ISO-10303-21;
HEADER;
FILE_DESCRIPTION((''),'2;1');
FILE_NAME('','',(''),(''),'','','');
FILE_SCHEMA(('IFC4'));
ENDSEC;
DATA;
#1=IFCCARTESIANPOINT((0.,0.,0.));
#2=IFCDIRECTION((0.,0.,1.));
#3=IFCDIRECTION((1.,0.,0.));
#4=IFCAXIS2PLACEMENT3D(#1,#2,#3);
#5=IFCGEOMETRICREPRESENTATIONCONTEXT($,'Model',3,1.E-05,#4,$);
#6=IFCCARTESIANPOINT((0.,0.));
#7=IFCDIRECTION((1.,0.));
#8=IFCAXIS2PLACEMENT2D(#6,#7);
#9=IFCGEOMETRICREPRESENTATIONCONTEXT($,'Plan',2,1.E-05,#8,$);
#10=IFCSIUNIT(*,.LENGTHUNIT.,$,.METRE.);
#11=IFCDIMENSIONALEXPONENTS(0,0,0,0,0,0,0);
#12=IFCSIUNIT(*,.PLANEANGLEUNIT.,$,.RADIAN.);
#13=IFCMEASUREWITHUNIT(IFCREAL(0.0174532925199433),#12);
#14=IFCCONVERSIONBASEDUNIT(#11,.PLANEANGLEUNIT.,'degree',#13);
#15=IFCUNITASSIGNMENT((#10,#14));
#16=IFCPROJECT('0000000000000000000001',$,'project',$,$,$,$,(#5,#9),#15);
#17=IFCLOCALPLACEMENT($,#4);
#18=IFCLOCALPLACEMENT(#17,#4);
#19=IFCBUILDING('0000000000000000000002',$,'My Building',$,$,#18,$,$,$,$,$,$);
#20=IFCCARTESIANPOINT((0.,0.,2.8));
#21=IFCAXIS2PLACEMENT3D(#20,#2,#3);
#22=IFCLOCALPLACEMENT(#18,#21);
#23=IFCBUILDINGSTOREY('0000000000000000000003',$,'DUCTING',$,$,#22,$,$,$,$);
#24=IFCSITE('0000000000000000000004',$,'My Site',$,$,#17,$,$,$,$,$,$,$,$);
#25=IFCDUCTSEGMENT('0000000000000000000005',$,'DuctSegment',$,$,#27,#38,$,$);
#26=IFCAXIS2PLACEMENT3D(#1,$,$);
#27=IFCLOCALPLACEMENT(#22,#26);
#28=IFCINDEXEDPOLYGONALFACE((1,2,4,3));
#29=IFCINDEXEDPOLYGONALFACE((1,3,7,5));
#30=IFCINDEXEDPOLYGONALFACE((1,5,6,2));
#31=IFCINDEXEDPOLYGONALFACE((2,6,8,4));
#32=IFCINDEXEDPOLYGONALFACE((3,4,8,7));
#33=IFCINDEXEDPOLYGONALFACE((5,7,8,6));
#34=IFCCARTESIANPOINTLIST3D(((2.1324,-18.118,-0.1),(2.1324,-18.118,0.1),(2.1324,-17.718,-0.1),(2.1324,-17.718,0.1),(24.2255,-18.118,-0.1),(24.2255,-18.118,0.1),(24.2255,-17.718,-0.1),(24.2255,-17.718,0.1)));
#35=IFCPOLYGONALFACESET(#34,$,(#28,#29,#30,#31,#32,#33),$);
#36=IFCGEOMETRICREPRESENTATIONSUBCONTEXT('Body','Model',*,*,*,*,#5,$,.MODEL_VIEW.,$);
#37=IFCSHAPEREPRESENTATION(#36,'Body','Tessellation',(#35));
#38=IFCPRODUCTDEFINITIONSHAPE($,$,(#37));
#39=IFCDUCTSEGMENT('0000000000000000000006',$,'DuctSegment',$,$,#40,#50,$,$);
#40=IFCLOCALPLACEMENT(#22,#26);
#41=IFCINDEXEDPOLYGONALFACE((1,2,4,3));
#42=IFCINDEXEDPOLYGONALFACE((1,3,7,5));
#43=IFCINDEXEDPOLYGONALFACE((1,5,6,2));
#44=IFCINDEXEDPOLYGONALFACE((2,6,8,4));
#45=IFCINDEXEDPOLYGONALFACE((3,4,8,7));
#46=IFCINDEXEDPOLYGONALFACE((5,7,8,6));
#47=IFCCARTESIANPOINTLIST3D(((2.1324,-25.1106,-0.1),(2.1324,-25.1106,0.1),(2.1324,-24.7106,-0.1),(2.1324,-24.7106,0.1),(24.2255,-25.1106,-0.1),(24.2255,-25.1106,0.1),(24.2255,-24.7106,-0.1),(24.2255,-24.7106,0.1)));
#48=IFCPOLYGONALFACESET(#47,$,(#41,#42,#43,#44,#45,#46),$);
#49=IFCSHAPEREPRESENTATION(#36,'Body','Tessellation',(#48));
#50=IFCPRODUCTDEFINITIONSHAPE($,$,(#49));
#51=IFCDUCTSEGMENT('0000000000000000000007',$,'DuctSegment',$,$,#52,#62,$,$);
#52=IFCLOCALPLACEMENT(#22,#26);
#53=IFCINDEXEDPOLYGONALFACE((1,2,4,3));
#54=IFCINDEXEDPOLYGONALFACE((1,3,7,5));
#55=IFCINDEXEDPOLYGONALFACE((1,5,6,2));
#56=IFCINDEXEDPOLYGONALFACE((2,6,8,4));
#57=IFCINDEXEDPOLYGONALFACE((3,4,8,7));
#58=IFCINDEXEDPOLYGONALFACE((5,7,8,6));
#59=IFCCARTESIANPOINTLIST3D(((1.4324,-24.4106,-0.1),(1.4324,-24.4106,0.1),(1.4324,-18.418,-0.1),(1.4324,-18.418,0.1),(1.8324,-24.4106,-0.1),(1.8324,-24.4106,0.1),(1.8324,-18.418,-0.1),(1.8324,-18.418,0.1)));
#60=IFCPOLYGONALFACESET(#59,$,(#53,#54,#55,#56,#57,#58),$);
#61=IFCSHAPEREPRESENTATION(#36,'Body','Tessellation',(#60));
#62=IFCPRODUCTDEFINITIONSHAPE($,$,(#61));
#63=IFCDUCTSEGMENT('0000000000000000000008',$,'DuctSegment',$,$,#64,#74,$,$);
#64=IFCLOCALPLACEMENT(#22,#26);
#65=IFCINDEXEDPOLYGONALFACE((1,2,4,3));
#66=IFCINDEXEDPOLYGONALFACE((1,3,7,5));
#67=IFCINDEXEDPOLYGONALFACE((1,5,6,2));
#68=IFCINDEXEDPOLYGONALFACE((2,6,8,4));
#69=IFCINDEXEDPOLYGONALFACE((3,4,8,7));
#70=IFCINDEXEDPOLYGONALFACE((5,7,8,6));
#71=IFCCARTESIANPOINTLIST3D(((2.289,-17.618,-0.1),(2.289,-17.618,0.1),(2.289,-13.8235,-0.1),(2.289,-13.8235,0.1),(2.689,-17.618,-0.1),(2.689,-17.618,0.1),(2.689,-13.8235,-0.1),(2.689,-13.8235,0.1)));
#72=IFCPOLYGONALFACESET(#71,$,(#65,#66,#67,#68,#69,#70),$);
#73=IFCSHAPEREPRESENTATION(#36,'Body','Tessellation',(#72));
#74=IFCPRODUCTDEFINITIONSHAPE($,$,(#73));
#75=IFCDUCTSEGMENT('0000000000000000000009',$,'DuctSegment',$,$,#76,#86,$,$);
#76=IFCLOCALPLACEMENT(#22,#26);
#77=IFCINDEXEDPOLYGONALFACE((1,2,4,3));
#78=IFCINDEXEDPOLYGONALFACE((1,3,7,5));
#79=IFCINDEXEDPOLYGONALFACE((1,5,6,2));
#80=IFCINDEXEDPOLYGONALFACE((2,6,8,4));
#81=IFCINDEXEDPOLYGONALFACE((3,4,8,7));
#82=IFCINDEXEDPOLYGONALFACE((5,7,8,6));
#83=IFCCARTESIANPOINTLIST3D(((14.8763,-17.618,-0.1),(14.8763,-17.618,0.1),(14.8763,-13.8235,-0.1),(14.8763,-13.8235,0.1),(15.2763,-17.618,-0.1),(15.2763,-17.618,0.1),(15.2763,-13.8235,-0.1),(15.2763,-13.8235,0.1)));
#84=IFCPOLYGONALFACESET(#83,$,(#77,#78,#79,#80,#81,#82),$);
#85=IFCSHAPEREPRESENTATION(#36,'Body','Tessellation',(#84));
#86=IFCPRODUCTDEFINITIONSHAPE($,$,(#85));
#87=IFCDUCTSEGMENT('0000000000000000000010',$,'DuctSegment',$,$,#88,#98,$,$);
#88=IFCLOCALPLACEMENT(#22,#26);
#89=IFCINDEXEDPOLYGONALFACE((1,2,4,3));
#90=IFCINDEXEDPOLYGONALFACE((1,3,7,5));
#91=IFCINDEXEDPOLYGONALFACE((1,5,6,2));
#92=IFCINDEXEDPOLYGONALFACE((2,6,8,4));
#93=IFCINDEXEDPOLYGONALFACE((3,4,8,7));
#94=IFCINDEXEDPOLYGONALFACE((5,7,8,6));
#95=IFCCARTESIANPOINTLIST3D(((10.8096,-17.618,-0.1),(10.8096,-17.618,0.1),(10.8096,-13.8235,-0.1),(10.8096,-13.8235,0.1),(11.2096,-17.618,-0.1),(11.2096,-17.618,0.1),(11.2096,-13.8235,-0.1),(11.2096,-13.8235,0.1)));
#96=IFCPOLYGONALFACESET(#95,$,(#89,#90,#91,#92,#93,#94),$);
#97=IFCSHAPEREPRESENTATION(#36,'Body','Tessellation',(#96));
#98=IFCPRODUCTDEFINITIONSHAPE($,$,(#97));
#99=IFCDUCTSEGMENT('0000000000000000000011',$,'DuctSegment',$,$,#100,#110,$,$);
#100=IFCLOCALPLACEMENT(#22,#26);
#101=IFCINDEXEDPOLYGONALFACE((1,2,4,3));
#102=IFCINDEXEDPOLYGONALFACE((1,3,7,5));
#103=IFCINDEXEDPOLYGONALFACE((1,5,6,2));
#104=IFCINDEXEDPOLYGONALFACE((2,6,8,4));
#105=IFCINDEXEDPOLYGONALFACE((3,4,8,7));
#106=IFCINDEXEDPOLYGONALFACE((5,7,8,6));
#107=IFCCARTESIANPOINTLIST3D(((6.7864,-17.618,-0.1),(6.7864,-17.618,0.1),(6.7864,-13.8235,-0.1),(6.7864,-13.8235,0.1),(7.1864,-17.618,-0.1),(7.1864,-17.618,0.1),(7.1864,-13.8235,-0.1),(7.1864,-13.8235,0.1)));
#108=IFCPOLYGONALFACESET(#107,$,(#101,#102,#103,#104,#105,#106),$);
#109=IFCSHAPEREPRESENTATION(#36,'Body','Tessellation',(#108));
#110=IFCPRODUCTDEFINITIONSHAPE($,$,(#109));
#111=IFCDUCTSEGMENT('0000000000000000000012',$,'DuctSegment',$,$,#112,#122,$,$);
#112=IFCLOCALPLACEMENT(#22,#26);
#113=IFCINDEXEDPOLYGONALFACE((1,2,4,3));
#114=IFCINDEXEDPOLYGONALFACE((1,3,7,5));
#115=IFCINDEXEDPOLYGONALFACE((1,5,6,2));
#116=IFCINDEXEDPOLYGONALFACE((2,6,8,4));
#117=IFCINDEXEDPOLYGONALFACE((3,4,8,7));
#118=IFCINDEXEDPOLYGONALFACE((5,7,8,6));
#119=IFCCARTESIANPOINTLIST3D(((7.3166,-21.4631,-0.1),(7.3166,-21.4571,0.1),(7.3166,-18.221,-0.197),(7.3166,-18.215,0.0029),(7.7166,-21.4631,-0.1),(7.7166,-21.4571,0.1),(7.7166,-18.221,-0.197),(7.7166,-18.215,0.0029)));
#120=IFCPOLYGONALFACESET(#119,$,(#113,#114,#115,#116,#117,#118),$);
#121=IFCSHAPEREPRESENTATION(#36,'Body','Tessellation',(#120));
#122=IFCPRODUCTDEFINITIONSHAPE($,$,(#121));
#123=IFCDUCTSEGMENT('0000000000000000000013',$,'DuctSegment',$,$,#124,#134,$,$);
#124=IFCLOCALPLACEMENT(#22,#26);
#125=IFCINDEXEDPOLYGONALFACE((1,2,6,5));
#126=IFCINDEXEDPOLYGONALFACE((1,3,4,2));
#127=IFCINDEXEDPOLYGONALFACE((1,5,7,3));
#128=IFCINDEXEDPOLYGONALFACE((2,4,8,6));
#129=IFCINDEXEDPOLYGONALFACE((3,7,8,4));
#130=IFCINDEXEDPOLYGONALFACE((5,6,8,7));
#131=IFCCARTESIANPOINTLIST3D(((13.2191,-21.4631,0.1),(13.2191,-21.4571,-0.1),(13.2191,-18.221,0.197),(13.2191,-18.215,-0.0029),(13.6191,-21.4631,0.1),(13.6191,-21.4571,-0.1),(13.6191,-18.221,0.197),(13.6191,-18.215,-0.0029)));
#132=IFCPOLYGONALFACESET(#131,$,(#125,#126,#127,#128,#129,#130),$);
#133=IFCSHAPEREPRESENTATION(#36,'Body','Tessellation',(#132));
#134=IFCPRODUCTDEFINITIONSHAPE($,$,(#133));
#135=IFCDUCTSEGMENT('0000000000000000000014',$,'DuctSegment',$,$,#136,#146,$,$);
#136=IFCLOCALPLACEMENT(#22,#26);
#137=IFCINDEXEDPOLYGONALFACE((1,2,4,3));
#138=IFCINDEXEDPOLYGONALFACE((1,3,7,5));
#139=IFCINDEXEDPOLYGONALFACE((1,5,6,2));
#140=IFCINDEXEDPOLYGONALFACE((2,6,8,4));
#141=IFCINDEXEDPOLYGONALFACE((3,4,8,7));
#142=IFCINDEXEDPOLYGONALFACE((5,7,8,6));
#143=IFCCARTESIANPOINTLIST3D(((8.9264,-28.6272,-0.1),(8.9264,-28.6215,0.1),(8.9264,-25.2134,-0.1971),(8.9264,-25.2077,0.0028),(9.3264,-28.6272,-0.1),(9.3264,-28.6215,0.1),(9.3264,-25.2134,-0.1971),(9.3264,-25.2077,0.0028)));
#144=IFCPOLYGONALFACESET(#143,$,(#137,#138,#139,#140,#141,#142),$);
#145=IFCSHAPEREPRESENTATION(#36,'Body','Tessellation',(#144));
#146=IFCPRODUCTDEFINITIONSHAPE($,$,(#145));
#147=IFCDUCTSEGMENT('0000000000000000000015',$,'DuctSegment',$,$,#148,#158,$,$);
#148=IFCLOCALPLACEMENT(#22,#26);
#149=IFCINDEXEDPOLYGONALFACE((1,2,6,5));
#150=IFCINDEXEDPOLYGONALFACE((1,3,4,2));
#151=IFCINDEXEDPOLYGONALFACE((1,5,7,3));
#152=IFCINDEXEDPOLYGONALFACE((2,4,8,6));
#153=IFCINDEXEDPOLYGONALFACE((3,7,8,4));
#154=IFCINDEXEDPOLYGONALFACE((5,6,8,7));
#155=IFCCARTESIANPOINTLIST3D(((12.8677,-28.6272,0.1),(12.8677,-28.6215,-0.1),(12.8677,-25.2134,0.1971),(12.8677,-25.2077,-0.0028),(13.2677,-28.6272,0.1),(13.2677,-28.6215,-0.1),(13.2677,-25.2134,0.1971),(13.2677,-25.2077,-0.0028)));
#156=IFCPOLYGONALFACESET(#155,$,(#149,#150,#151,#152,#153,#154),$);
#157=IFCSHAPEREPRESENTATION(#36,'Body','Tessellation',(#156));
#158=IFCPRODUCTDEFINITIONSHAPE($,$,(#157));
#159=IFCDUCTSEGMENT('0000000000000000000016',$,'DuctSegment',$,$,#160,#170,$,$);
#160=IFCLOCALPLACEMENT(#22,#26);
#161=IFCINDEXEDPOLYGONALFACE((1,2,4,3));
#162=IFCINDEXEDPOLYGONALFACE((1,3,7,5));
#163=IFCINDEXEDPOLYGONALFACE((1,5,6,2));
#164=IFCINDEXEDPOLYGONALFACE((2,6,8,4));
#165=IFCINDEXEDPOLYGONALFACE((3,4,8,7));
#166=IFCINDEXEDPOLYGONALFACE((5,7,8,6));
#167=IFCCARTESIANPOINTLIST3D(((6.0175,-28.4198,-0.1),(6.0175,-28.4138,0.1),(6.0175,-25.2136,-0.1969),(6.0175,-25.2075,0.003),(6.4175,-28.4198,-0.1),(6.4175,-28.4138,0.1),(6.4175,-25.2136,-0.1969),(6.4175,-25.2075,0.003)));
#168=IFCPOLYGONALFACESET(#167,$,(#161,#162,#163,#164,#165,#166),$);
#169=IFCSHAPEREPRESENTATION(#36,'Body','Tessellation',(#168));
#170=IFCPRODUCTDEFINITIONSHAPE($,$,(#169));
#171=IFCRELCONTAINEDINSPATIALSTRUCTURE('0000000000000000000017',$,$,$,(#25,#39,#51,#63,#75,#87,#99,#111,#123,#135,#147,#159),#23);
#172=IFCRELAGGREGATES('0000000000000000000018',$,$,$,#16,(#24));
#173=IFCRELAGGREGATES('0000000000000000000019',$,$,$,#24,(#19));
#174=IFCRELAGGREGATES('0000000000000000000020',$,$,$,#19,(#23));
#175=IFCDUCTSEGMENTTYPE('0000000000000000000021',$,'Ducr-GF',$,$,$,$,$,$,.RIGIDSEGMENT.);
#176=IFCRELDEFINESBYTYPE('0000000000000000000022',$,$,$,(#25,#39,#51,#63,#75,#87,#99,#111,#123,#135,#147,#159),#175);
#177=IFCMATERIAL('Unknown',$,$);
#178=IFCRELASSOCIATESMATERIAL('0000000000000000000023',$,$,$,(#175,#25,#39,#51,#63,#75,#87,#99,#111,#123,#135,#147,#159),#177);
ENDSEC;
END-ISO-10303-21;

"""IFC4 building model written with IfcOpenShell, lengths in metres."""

from ifc_helpers import new_model, entity, si_unit, converted_unit, frame, origin_with_axes, origin_2d_with_axis, place, context, subcontext, project, spatial, rectangle, extrude, material, material_profile, profile_set, profile_usage, type_object, element, save


model = new_model("IFC4")

# Units and contexts
model_context = context("Model", 3, precision=1e-05, world=origin_with_axes())
plan_context = context("Plan", 2, precision=1e-05, world=origin_2d_with_axis())
body_context = subcontext(model_context, "Body", "Model", "MODEL_VIEW")
ifc_project = project(units=[si_unit("LENGTHUNIT", "METRE"), converted_unit("PLANEANGLEUNIT", "degree", entity("IfcReal", 0.0174532925199433), si_unit("PLANEANGLEUNIT", "RADIAN"), dimensions=[0, 0, 0, 0, 0, 0, 0])], contexts=[model_context, plan_context])

# Site, building, storey
site_placement = place(None, origin_with_axes())
site = spatial("IfcSite", under=ifc_project, at=site_placement, Name="My Site")
building_placement = place(site_placement, origin_with_axes())
building = spatial("IfcBuilding", under=site, at=building_placement, Name="My Building")
storey_placement = place(building_placement, frame((0.0, 0.0, 2.8), z_axis=(0.0, 0.0, 1.0), x_axis=(1.0, 0.0, 0.0)))
storey = spatial("IfcBuildingStorey", under=building, at=storey_placement, Name="DUCTING")

# Duct segments
ifc_material = material(Name="Unknown")
ifc_material_profile_1 = material_profile(ifc_material, rectangle(XDim=0.4, YDim=0.2))
ifc_profile_set_1 = profile_set([ifc_material_profile_1])
ifc_profile_usage_1 = profile_usage(ifc_profile_set_1, cardinal=5)
duct_segment_type = type_object("IfcDuctSegmentType", Name="Ducr-GF", PredefinedType="RIGIDSEGMENT", material=ifc_profile_set_1)
duct_segment_1_placement = place(storey_placement, frame((2.1324, -17.918, 0.0), z_axis=(1.0, 0.0, 0.0), x_axis=(0.0, 1.0, 0.0)))
element("IfcDuctSegment", 1, at=duct_segment_1_placement, inside=storey, type_object=duct_segment_type, material=ifc_profile_usage_1, Name="DuctSegment", context=body_context, shape_type="SweptSolid", body=[
    extrude(rectangle(XDim=0.4, YDim=0.2), origin_with_axes(), (0.0, 0.0, 1.0), 22.0931),
])
ifc_profile_usage_2 = profile_usage(ifc_profile_set_1, cardinal=5)
duct_segment_2_placement = place(storey_placement, frame((2.1324, -24.9106, 0.0), z_axis=(1.0, 0.0, 0.0), x_axis=(0.0, 1.0, 0.0)))
element("IfcDuctSegment", 2, at=duct_segment_2_placement, inside=storey, type_object=duct_segment_type, material=ifc_profile_usage_2, Name="DuctSegment", context=body_context, shape_type="SweptSolid", body=[
    extrude(rectangle(XDim=0.4, YDim=0.2), origin_with_axes(), (0.0, 0.0, 1.0), 22.0931),
])
ifc_profile_usage_3 = profile_usage(ifc_profile_set_1, cardinal=5)
duct_segment_3_placement = place(storey_placement, frame((1.6324, -18.418, 0.0), z_axis=(0.0, -1.0, 0.0), x_axis=(1.0, 0.0, 0.0)))
element("IfcDuctSegment", 3, at=duct_segment_3_placement, inside=storey, type_object=duct_segment_type, material=ifc_profile_usage_3, Name="DuctSegment", context=body_context, shape_type="SweptSolid", body=[
    extrude(rectangle(XDim=0.4, YDim=0.2), origin_with_axes(), (0.0, 0.0, 1.0), 5.9926),
])
ifc_profile_usage_4 = profile_usage(ifc_profile_set_1, cardinal=5)
duct_segment_4_placement = place(storey_placement, frame((2.489, -17.618, 0.0), z_axis=(0.0, 1.0, 0.0), x_axis=(-1.0, 0.0, 0.0)))
element("IfcDuctSegment", 4, at=duct_segment_4_placement, inside=storey, type_object=duct_segment_type, material=ifc_profile_usage_4, Name="DuctSegment", context=body_context, shape_type="SweptSolid", body=[
    extrude(rectangle(XDim=0.4, YDim=0.2), origin_with_axes(), (0.0, 0.0, 1.0), 3.7945),
])
ifc_profile_usage_5 = profile_usage(ifc_profile_set_1, cardinal=5)
duct_segment_5_placement = place(storey_placement, frame((15.0763, -17.618, 0.0), z_axis=(0.0, 1.0, 0.0), x_axis=(-1.0, 0.0, 0.0)))
element("IfcDuctSegment", 5, at=duct_segment_5_placement, inside=storey, type_object=duct_segment_type, material=ifc_profile_usage_5, Name="DuctSegment", context=body_context, shape_type="SweptSolid", body=[
    extrude(rectangle(XDim=0.4, YDim=0.2), origin_with_axes(), (0.0, 0.0, 1.0), 3.7945),
])
ifc_profile_usage_6 = profile_usage(ifc_profile_set_1, cardinal=5)
duct_segment_6_placement = place(storey_placement, frame((11.0096, -17.618, 0.0), z_axis=(0.0, 1.0, 0.0), x_axis=(-1.0, 0.0, 0.0)))
element("IfcDuctSegment", 6, at=duct_segment_6_placement, inside=storey, type_object=duct_segment_type, material=ifc_profile_usage_6, Name="DuctSegment", context=body_context, shape_type="SweptSolid", body=[
    extrude(rectangle(XDim=0.4, YDim=0.2), origin_with_axes(), (0.0, 0.0, 1.0), 3.7945),
])
ifc_profile_usage_7 = profile_usage(ifc_profile_set_1, cardinal=5)
duct_segment_7_placement = place(storey_placement, frame((6.9864, -17.618, 0.0), z_axis=(0.0, 1.0, 0.0), x_axis=(-1.0, 0.0, 0.0)))
element("IfcDuctSegment", 7, at=duct_segment_7_placement, inside=storey, type_object=duct_segment_type, material=ifc_profile_usage_7, Name="DuctSegment", context=body_context, shape_type="SweptSolid", body=[
    extrude(rectangle(XDim=0.4, YDim=0.2), origin_with_axes(), (0.0, 0.0, 1.0), 3.7945),
])
ifc_profile_usage_8 = profile_usage(ifc_profile_set_1, cardinal=5)
duct_segment_8_placement = place(storey_placement, frame((7.5166, -18.218, -0.097), z_axis=(0.0, -0.999553, 0.029909), x_axis=(1.0, 0.0, 0.0)))
element("IfcDuctSegment", 8, at=duct_segment_8_placement, inside=storey, type_object=duct_segment_type, material=ifc_profile_usage_8, Name="DuctSegment", context=body_context, shape_type="SweptSolid", body=[
    extrude(rectangle(XDim=0.4, YDim=0.2), origin_with_axes(), (0.0, 0.0, 1.0), 3.2435),
])
ifc_profile_usage_9 = profile_usage(ifc_profile_set_1, cardinal=5)
duct_segment_9_placement = place(storey_placement, frame((13.4191, -18.218, 0.097), z_axis=(-0.000001, -0.999553, -0.029908), x_axis=(1.0, -0.000001, 0.0)))
element("IfcDuctSegment", 9, at=duct_segment_9_placement, inside=storey, type_object=duct_segment_type, material=ifc_profile_usage_9, Name="DuctSegment", context=body_context, shape_type="SweptSolid", body=[
    extrude(rectangle(XDim=0.4, YDim=0.2), origin_with_axes(), (0.0, 0.0, 1.0), 3.2435),
])
ifc_profile_usage_10 = profile_usage(ifc_profile_set_1, cardinal=5)
duct_segment_10_placement = place(storey_placement, frame((9.1264, -25.2106, -0.0972), z_axis=(0.0, -0.999595, 0.028448), x_axis=(1.0, 0.0, 0.0)))
element("IfcDuctSegment", 10, at=duct_segment_10_placement, inside=storey, type_object=duct_segment_type, material=ifc_profile_usage_10, Name="DuctSegment", context=body_context, shape_type="SweptSolid", body=[
    extrude(rectangle(XDim=0.4, YDim=0.2), origin_with_axes(), (0.0, 0.0, 1.0), 3.4152),
])
ifc_profile_usage_11 = profile_usage(ifc_profile_set_1, cardinal=5)
duct_segment_11_placement = place(storey_placement, frame((13.0677, -25.2106, 0.0972), z_axis=(-0.000001, -0.999595, -0.028447), x_axis=(1.0, -0.000001, 0.0)))
element("IfcDuctSegment", 11, at=duct_segment_11_placement, inside=storey, type_object=duct_segment_type, material=ifc_profile_usage_11, Name="DuctSegment", context=body_context, shape_type="SweptSolid", body=[
    extrude(rectangle(XDim=0.4, YDim=0.2), origin_with_axes(), (0.0, 0.0, 1.0), 3.4152),
])
ifc_profile_usage_12 = profile_usage(ifc_profile_set_1, cardinal=5)
duct_segment_12_placement = place(storey_placement, frame((6.2175, -25.2106, -0.097), z_axis=(0.0, -0.999543, 0.030232), x_axis=(1.0, 0.0, 0.0)))
element("IfcDuctSegment", 12, at=duct_segment_12_placement, inside=storey, type_object=duct_segment_type, material=ifc_profile_usage_12, Name="DuctSegment", context=body_context, shape_type="SweptSolid", body=[
    extrude(rectangle(XDim=0.4, YDim=0.2), origin_with_axes(), (0.0, 0.0, 1.0), 3.2077),
])

save(model, "model.ifc")
